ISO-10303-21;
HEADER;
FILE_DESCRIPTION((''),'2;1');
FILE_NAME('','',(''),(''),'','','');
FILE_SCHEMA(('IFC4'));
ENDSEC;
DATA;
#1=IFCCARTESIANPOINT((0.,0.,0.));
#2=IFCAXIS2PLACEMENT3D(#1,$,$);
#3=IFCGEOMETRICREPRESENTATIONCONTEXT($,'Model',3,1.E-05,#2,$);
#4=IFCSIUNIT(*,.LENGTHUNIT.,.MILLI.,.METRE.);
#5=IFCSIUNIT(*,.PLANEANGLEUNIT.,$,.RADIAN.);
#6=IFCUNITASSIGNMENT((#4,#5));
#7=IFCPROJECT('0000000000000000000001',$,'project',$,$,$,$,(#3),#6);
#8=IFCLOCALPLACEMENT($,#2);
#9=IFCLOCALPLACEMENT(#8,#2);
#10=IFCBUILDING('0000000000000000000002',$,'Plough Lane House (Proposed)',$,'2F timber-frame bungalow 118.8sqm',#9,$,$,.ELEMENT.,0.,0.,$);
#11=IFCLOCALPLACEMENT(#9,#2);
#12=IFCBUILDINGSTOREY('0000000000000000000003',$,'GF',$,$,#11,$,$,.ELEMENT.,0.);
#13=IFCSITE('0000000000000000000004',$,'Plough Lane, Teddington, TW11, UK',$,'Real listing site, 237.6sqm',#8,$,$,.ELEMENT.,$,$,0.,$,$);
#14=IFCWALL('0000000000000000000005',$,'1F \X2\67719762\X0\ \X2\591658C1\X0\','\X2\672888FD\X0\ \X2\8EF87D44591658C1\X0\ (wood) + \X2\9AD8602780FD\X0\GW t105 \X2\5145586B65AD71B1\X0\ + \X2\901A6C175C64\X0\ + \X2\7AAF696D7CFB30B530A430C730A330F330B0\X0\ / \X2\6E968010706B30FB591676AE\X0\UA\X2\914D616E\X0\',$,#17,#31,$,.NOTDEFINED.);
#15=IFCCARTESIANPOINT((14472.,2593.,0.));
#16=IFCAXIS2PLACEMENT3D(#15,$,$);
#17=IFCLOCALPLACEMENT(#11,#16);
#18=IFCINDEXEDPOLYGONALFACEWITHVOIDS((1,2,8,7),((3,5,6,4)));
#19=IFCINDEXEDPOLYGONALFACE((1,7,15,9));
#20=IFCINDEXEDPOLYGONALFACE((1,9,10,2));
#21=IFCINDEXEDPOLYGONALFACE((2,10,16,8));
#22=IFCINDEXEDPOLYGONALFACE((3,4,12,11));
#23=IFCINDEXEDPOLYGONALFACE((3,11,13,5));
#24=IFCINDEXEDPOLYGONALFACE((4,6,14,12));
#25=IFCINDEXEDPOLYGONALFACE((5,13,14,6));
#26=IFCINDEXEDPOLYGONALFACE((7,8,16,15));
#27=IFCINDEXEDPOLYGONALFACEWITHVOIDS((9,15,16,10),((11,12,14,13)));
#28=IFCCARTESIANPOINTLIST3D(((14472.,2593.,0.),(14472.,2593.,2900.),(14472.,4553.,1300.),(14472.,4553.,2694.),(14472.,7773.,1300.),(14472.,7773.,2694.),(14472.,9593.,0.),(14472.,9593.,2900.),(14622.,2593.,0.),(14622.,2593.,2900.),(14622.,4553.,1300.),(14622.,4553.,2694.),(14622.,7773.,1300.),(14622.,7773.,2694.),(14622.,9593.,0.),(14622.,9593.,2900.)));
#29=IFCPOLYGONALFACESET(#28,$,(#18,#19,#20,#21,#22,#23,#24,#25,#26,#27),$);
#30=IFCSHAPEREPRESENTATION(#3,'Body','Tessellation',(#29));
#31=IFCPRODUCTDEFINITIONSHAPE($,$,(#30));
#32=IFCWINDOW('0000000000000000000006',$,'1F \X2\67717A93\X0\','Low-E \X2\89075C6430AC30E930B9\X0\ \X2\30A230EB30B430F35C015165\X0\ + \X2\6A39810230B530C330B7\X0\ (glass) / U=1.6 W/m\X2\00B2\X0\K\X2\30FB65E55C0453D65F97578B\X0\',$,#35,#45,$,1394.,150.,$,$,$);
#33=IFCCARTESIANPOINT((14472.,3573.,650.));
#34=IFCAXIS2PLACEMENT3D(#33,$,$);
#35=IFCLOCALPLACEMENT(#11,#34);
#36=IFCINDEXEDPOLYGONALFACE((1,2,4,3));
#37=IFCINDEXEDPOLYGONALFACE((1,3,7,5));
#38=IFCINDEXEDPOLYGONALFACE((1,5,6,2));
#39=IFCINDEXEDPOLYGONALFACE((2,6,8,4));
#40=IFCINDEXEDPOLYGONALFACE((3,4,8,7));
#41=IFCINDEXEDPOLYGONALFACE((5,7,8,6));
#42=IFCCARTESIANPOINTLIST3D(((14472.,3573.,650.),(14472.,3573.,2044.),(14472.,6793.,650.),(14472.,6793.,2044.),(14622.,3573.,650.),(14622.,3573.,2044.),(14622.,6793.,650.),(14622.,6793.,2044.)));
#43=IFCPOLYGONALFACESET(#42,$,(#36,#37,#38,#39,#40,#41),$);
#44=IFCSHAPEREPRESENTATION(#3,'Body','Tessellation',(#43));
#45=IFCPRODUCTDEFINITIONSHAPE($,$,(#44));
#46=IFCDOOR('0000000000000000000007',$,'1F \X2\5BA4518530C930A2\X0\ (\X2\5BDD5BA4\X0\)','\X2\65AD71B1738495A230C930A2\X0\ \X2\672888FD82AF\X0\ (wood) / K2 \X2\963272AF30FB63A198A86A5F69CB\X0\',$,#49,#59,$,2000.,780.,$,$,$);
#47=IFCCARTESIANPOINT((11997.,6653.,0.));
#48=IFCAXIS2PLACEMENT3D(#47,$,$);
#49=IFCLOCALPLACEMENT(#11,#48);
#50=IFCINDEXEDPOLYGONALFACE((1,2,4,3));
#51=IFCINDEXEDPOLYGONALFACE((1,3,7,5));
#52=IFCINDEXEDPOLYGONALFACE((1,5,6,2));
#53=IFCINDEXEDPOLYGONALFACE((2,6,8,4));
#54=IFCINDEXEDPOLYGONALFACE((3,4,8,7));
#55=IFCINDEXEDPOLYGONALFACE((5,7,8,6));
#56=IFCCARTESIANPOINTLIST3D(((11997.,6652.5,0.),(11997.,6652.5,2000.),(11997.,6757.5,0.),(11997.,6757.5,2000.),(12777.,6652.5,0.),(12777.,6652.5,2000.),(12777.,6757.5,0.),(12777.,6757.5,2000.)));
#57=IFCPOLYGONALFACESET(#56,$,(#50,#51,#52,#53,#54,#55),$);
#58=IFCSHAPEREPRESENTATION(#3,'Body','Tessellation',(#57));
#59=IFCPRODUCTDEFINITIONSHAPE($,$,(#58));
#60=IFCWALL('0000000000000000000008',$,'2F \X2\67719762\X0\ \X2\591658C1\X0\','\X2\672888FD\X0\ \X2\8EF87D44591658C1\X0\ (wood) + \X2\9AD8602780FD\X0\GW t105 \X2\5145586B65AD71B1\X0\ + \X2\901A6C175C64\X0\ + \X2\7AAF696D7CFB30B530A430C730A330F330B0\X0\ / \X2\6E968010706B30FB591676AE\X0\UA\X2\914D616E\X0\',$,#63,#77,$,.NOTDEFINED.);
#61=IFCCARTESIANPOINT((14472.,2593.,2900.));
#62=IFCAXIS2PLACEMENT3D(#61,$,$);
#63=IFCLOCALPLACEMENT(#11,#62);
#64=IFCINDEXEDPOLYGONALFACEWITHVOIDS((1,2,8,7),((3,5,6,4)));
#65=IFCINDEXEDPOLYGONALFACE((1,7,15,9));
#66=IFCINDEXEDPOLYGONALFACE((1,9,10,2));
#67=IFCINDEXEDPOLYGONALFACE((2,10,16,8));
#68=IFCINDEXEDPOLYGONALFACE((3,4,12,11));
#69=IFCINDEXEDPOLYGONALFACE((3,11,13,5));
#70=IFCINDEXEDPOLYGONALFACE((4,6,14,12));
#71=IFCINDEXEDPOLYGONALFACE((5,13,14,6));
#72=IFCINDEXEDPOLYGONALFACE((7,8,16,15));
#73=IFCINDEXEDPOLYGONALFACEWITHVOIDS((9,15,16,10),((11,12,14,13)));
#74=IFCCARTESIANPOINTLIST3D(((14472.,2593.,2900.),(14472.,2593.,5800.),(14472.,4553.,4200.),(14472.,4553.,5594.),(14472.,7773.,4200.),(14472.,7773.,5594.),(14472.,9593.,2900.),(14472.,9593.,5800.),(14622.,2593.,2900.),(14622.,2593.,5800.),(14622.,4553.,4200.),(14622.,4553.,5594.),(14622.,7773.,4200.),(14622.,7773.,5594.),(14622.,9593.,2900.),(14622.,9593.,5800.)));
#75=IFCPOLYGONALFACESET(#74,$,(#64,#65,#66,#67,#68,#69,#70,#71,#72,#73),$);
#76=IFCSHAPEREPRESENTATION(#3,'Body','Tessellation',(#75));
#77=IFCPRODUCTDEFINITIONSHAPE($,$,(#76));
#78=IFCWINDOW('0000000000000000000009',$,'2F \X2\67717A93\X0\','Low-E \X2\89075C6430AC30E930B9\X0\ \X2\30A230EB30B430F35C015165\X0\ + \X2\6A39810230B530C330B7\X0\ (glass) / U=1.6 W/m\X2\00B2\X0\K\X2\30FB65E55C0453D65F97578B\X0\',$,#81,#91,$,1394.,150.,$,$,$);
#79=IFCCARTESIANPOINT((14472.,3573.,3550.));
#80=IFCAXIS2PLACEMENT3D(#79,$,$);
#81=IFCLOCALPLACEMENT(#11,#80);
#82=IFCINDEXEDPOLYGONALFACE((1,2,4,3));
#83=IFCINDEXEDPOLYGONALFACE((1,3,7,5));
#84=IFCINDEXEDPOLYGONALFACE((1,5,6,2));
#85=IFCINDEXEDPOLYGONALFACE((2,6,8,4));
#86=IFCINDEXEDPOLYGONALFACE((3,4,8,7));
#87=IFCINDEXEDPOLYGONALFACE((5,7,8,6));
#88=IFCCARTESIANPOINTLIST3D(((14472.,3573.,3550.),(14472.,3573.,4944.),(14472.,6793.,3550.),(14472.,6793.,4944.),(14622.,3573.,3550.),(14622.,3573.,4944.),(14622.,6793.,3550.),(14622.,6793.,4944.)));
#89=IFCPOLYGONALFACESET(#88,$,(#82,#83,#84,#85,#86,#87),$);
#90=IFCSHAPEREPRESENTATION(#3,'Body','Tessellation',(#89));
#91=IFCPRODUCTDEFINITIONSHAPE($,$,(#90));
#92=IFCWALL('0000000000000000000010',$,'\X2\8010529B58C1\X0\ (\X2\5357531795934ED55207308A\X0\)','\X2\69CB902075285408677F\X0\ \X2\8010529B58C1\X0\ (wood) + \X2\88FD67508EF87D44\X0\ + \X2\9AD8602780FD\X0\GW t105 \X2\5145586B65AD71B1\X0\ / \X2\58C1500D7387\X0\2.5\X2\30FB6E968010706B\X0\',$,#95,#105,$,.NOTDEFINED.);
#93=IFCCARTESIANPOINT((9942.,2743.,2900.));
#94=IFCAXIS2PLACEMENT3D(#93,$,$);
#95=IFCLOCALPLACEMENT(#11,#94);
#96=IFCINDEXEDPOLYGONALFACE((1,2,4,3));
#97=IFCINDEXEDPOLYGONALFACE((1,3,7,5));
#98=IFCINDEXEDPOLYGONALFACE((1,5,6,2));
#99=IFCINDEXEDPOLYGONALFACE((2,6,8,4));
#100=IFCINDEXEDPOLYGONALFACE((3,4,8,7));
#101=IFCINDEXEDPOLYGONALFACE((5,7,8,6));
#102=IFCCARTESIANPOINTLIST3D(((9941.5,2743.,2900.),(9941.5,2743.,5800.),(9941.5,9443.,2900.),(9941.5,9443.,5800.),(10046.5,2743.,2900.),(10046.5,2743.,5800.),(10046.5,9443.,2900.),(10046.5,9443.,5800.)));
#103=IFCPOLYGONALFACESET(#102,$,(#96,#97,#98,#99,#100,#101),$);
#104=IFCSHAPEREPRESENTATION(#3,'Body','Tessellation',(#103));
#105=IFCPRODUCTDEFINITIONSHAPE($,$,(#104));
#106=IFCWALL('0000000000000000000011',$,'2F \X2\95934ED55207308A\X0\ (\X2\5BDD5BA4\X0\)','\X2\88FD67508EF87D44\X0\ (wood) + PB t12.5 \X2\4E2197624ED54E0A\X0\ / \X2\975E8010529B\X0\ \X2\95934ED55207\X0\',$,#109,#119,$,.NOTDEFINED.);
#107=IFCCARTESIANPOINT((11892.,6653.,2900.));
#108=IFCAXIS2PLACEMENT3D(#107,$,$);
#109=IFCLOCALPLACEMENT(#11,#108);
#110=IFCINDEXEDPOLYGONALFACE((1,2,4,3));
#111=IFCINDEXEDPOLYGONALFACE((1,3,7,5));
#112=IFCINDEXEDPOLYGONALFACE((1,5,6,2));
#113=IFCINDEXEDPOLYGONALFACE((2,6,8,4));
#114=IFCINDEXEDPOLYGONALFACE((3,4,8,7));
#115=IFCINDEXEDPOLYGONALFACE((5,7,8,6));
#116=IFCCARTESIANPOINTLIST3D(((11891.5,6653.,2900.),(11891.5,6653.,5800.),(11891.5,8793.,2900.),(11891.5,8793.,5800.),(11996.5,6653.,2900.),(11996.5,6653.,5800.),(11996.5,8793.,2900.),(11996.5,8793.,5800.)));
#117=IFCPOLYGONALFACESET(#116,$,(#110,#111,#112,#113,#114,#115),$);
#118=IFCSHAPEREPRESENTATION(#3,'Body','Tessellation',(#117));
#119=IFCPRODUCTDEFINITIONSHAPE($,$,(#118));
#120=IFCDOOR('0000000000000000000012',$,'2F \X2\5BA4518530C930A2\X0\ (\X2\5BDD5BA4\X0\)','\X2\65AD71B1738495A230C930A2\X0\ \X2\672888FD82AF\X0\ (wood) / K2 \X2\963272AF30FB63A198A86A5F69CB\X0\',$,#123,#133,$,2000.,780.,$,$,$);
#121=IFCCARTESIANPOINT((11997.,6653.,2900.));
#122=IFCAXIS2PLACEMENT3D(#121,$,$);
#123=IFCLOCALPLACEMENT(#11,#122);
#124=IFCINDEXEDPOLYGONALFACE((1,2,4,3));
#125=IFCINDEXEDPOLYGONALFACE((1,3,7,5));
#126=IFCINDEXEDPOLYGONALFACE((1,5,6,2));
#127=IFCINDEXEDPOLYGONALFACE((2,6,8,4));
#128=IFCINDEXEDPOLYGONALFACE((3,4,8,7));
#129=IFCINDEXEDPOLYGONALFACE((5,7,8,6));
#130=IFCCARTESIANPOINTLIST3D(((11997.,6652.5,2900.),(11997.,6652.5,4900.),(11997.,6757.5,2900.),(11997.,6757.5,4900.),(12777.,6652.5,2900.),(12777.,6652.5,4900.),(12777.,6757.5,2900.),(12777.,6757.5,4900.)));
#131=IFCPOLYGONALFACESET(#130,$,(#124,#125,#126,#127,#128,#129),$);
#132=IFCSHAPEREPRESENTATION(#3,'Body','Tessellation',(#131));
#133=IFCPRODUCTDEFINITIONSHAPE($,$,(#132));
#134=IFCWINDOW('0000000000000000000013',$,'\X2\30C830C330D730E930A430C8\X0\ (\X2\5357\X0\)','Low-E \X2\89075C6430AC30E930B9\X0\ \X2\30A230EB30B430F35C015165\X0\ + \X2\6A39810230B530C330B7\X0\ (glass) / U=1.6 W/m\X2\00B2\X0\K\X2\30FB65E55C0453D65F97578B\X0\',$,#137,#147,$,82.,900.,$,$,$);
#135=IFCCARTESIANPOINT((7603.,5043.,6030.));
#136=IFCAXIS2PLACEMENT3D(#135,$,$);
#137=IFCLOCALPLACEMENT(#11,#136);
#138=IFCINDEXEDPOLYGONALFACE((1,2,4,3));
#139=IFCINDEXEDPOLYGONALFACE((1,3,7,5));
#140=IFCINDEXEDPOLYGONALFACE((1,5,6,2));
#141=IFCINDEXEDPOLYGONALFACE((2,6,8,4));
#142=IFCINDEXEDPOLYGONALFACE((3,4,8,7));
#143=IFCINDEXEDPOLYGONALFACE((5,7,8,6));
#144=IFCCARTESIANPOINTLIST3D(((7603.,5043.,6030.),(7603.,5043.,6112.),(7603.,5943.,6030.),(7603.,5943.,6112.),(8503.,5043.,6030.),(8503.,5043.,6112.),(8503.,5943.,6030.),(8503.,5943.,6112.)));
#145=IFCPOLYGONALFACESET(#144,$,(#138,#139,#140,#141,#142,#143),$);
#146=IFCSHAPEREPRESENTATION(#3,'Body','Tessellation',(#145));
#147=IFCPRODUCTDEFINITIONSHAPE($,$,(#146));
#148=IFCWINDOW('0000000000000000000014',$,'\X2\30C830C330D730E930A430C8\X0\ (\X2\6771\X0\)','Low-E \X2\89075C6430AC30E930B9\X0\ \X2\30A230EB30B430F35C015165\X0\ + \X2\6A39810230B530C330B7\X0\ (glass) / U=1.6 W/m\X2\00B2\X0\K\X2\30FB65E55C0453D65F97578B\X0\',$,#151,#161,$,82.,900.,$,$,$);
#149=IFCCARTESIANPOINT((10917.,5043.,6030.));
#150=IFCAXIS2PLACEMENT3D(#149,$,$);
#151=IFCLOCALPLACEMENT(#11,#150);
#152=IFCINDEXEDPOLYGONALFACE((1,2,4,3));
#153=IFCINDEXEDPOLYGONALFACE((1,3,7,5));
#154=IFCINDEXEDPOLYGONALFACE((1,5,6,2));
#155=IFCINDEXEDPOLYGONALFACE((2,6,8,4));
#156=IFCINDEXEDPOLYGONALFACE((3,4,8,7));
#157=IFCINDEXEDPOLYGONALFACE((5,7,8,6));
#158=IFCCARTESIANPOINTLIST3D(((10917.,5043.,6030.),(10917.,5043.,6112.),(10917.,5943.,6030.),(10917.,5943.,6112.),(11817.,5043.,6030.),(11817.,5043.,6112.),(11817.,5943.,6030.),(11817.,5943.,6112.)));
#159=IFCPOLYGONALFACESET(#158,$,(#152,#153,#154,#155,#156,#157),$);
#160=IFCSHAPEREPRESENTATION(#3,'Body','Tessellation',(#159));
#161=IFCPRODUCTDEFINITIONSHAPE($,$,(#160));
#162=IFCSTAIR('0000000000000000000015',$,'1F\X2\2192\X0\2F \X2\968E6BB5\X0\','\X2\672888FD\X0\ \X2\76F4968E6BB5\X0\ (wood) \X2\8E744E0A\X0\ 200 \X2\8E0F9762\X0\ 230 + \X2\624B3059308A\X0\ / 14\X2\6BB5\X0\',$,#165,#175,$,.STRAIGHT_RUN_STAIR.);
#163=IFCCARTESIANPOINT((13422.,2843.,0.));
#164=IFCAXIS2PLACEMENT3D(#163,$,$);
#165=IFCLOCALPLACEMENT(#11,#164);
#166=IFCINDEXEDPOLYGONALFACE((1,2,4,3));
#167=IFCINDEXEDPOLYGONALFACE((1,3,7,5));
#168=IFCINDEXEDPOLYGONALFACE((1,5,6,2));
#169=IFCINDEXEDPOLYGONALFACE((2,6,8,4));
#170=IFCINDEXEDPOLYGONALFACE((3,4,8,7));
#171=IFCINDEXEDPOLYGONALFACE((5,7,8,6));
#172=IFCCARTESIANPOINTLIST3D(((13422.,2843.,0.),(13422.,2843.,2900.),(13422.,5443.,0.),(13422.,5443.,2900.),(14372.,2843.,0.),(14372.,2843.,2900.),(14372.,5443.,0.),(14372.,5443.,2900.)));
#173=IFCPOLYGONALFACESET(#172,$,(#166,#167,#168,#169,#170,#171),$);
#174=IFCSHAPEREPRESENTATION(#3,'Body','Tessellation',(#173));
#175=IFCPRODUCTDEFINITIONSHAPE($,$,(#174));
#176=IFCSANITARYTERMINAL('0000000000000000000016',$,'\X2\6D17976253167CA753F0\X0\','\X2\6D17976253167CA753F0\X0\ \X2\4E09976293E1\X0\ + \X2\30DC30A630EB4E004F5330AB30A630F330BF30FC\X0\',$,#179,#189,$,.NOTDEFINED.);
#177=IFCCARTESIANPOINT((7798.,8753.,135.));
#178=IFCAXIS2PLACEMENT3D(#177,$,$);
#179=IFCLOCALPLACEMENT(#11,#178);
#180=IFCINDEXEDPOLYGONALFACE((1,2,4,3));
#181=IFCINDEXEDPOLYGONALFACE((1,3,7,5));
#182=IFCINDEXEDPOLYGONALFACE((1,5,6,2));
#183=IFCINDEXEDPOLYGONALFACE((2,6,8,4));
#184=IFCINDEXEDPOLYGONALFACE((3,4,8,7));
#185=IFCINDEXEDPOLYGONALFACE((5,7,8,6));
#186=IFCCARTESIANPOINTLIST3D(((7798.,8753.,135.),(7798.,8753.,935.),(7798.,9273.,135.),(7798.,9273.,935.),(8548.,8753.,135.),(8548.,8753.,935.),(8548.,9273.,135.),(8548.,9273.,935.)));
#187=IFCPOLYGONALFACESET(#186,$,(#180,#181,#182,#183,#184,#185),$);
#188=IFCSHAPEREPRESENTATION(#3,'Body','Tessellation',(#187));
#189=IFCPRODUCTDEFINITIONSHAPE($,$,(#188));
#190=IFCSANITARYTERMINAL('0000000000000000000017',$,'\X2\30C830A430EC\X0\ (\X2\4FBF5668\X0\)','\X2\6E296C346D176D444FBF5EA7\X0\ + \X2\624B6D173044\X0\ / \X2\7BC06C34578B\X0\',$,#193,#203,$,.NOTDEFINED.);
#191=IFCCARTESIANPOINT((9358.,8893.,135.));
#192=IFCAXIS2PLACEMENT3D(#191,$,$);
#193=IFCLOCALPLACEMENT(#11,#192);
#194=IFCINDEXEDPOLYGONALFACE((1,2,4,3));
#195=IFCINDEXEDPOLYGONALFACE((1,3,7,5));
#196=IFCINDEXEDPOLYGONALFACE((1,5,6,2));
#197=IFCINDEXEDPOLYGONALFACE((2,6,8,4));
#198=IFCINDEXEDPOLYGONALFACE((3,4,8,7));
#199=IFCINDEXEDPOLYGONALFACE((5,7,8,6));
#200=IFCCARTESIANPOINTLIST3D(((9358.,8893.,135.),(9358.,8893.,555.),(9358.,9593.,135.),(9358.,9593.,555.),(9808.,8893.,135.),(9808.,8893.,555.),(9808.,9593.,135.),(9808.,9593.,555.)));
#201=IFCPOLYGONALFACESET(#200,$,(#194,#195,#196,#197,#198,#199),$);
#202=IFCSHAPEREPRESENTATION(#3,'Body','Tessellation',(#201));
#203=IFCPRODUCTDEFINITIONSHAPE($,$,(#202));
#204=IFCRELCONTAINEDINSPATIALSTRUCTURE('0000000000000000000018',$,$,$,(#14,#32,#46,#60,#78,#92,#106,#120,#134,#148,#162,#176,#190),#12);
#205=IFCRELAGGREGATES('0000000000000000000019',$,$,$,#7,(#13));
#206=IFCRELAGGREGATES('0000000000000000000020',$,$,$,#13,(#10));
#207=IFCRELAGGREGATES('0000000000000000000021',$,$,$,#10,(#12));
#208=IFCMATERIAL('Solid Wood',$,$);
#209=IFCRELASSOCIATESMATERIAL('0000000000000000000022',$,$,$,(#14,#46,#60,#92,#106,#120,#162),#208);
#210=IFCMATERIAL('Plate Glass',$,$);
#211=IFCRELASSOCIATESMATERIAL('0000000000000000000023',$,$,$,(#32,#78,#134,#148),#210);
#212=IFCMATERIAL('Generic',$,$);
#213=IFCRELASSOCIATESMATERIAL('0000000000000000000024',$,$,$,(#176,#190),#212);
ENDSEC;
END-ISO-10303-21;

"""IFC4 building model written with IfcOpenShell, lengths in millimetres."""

from ifc_helpers import new_model, si_unit, frame, frame_2d, origin, place, context, project, spatial, rectangle, extrude, material, element, fill, save


model = new_model("IFC4")

# Units and contexts
model_context = context("Model", 3, precision=1e-05, world=origin())
ifc_project = project(units=[si_unit("LENGTHUNIT", "METRE", prefix="MILLI"), si_unit("PLANEANGLEUNIT", "RADIAN")], contexts=[model_context])

# Site, building, storey
site_placement = place(None, origin())
site = spatial("IfcSite", under=ifc_project, at=site_placement, Name="Plough Lane, Teddington, TW11, UK", ObjectType="Real listing site, 237.6sqm", CompositionType="ELEMENT", RefElevation=0.0)
building_placement = place(site_placement, origin())
building = spatial("IfcBuilding", under=site, at=building_placement, Name="Plough Lane House (Proposed)", ObjectType="2F timber-frame bungalow 118.8sqm", CompositionType="ELEMENT", ElevationOfRefHeight=0.0, ElevationOfTerrain=0.0)
storey_placement = place(building_placement, origin())
storey = spatial("IfcBuildingStorey", under=building, at=storey_placement, Name="GF", CompositionType="ELEMENT", Elevation=0.0)

# Wall, opening, window
ifc_material_1 = material(Name="Solid Wood")
wall_1_placement = place(storey_placement, frame((14472.0, 2593.0, 0.0)))
wall_1 = element("IfcWall", 1, at=wall_1_placement, inside=storey, material=ifc_material_1, Name="1F 東面 外壁", Description="木製 軸組外壁 (wood) + 高性能GW t105 充填断熱 + 通気層 + 窯業系サイディング / 準耐火・外皮UA配慮", PredefinedType="NOTDEFINED", context=model_context, shape_type="SweptSolid", body=[
    extrude(rectangle(XDim=150.0, YDim=7000.0, at=frame_2d((75.0, 3500.0))), frame((14472.0, 2593.0, 0.0)), (0.0, 0.0, 1.0), 2900.0),
])
opening_1_placement = place(storey_placement, frame((14472.0, 3573.0, 650.0)))
opening_1 = element("IfcOpeningElement", 2, at=opening_1_placement, cuts=wall_1, PredefinedType="NOTDEFINED", context=model_context, shape_type="SweptSolid", body=[
    extrude(rectangle(XDim=150.0, YDim=3220.0, at=frame_2d((75.0, 1610.0))), frame((14472.0, 3573.0, 650.0)), (0.0, 0.0, 1.0), 1394.0),
])
ifc_material_2 = material(Name="Plate Glass")
window_1_placement = place(storey_placement, frame((14472.0, 3573.0, 650.0)))
window_1 = element("IfcWindow", 3, at=window_1_placement, inside=storey, material=ifc_material_2, Name="1F 東窓", Description="Low-E 複層ガラス アルゴン封入 + 樹脂サッシ (glass) / U=1.6 W/m²K・日射取得型", OverallHeight=1394.0, OverallWidth=150.0, context=model_context, shape_type="SweptSolid", body=[
    extrude(rectangle(XDim=150.0, YDim=3220.0, at=frame_2d((75.0, 1610.0))), frame((14472.0, 3573.0, 650.0)), (0.0, 0.0, 1.0), 1394.0),
])
fill(opening_1, window_1)

# Door
door_1_placement = place(storey_placement, frame((11997.0, 6653.0, 0.0)))
element("IfcDoor", 4, at=door_1_placement, inside=storey, material=ifc_material_1, Name="1F 室内ドア (寝室)", Description="断熱玄関ドア 木製芯 (wood) / K2 防犯・採風機構", OverallHeight=2000.0, OverallWidth=780.0, context=model_context, shape_type="SweptSolid", body=[
    extrude(rectangle(XDim=780.0, YDim=105.0, at=frame_2d((390.0, 52.0))), frame((11997.0, 6653.0, 0.0)), (0.0, 0.0, 1.0), 2000.0),
])

# Wall, opening, window
wall_2_placement = place(storey_placement, frame((14472.0, 2593.0, 2900.0)))
wall_2 = element("IfcWall", 5, at=wall_2_placement, inside=storey, material=ifc_material_1, Name="2F 東面 外壁", Description="木製 軸組外壁 (wood) + 高性能GW t105 充填断熱 + 通気層 + 窯業系サイディング / 準耐火・外皮UA配慮", PredefinedType="NOTDEFINED", context=model_context, shape_type="SweptSolid", body=[
    extrude(rectangle(XDim=150.0, YDim=7000.0, at=frame_2d((75.0, 3500.0))), frame((14472.0, 2593.0, 2900.0)), (0.0, 0.0, 1.0), 2900.0),
])
opening_2_placement = place(storey_placement, frame((14472.0, 3573.0, 3550.0)))
opening_2 = element("IfcOpeningElement", 6, at=opening_2_placement, cuts=wall_2, PredefinedType="NOTDEFINED", context=model_context, shape_type="SweptSolid", body=[
    extrude(rectangle(XDim=150.0, YDim=3220.0, at=frame_2d((75.0, 1610.0))), frame((14472.0, 3573.0, 3550.0)), (0.0, 0.0, 1.0), 1394.0),
])
window_2_placement = place(storey_placement, frame((14472.0, 3573.0, 3550.0)))
window_2 = element("IfcWindow", 7, at=window_2_placement, inside=storey, material=ifc_material_2, Name="2F 東窓", Description="Low-E 複層ガラス アルゴン封入 + 樹脂サッシ (glass) / U=1.6 W/m²K・日射取得型", OverallHeight=1394.0, OverallWidth=150.0, context=model_context, shape_type="SweptSolid", body=[
    extrude(rectangle(XDim=150.0, YDim=3220.0, at=frame_2d((75.0, 1610.0))), frame((14472.0, 3573.0, 3550.0)), (0.0, 0.0, 1.0), 1394.0),
])
fill(opening_2, window_2)

# Walls
wall_3_placement = place(storey_placement, frame((9942.0, 2743.0, 2900.0)))
element("IfcWall", 8, at=wall_3_placement, inside=storey, material=ifc_material_1, Name="耐力壁 (南北間仕切り)", Description="構造用合板 耐力壁 (wood) + 製材軸組 + 高性能GW t105 充填断熱 / 壁倍率2.5・準耐火", PredefinedType="NOTDEFINED", context=model_context, shape_type="SweptSolid", body=[
    extrude(rectangle(XDim=105.0, YDim=6700.0, at=frame_2d((52.0, 3350.0))), frame((9942.0, 2743.0, 2900.0)), (0.0, 0.0, 1.0), 2900.0),
])
wall_4_placement = place(storey_placement, frame((11892.0, 6653.0, 2900.0)))
element("IfcWall", 9, at=wall_4_placement, inside=storey, material=ifc_material_1, Name="2F 間仕切り (寝室)", Description="製材軸組 (wood) + PB t12.5 両面仕上 / 非耐力 間仕切", PredefinedType="NOTDEFINED", context=model_context, shape_type="SweptSolid", body=[
    extrude(rectangle(XDim=105.0, YDim=2140.0, at=frame_2d((52.0, 1070.0))), frame((11892.0, 6653.0, 2900.0)), (0.0, 0.0, 1.0), 2900.0),
])

# Door
door_2_placement = place(storey_placement, frame((11997.0, 6653.0, 2900.0)))
element("IfcDoor", 10, at=door_2_placement, inside=storey, material=ifc_material_1, Name="2F 室内ドア (寝室)", Description="断熱玄関ドア 木製芯 (wood) / K2 防犯・採風機構", OverallHeight=2000.0, OverallWidth=780.0, context=model_context, shape_type="SweptSolid", body=[
    extrude(rectangle(XDim=780.0, YDim=105.0, at=frame_2d((390.0, 52.0))), frame((11997.0, 6653.0, 2900.0)), (0.0, 0.0, 1.0), 2000.0),
])

# Windows
window_3_placement = place(storey_placement, frame((7603.0, 5043.0, 6030.0)))
element("IfcWindow", 11, at=window_3_placement, inside=storey, material=ifc_material_2, Name="トップライト (南)", Description="Low-E 複層ガラス アルゴン封入 + 樹脂サッシ (glass) / U=1.6 W/m²K・日射取得型", OverallHeight=82.0, OverallWidth=900.0, context=model_context, shape_type="SweptSolid", body=[
    extrude(rectangle(XDim=900.0, YDim=900.0, at=frame_2d((450.0, 450.0))), frame((7603.0, 5043.0, 6030.0)), (0.0, 0.0, 1.0), 82.0),
])
window_4_placement = place(storey_placement, frame((10917.0, 5043.0, 6030.0)))
element("IfcWindow", 12, at=window_4_placement, inside=storey, material=ifc_material_2, Name="トップライト (東)", Description="Low-E 複層ガラス アルゴン封入 + 樹脂サッシ (glass) / U=1.6 W/m²K・日射取得型", OverallHeight=82.0, OverallWidth=900.0, context=model_context, shape_type="SweptSolid", body=[
    extrude(rectangle(XDim=900.0, YDim=900.0, at=frame_2d((450.0, 450.0))), frame((10917.0, 5043.0, 6030.0)), (0.0, 0.0, 1.0), 82.0),
])

# Stair
stair_placement = place(storey_placement, frame((13422.0, 2843.0, 0.0)))
element("IfcStair", 13, at=stair_placement, inside=storey, material=ifc_material_1, Name="1F→2F 階段", Description="木製 直階段 (wood) 蹴上 200 踏面 230 + 手すり / 14段", PredefinedType="STRAIGHT_RUN_STAIR", context=model_context, shape_type="SweptSolid", body=[
    extrude(rectangle(XDim=950.0, YDim=2600.0, at=frame_2d((475.0, 1300.0))), frame((13422.0, 2843.0, 0.0)), (0.0, 0.0, 1.0), 2900.0),
])

# Sanitary terminals
ifc_material_3 = material(Name="Generic")
sanitary_terminal_1_placement = place(storey_placement, frame((7798.0, 8753.0, 135.0)))
element("IfcSanitaryTerminal", 14, at=sanitary_terminal_1_placement, inside=storey, material=ifc_material_3, Name="洗面化粧台", Description="洗面化粧台 三面鏡 + ボウル一体カウンター", PredefinedType="NOTDEFINED", context=model_context, shape_type="SweptSolid", body=[
    extrude(rectangle(XDim=750.0, YDim=520.0, at=frame_2d((375.0, 260.0))), frame((7798.0, 8753.0, 135.0)), (0.0, 0.0, 1.0), 800.0),
])
sanitary_terminal_2_placement = place(storey_placement, frame((9358.0, 8893.0, 135.0)))
element("IfcSanitaryTerminal", 15, at=sanitary_terminal_2_placement, inside=storey, material=ifc_material_3, Name="トイレ (便器)", Description="温水洗浄便座 + 手洗い / 節水型", PredefinedType="NOTDEFINED", context=model_context, shape_type="SweptSolid", body=[
    extrude(rectangle(XDim=450.0, YDim=700.0, at=frame_2d((225.0, 350.0))), frame((9358.0, 8893.0, 135.0)), (0.0, 0.0, 1.0), 420.0),
])

save(model, "model.ifc")
